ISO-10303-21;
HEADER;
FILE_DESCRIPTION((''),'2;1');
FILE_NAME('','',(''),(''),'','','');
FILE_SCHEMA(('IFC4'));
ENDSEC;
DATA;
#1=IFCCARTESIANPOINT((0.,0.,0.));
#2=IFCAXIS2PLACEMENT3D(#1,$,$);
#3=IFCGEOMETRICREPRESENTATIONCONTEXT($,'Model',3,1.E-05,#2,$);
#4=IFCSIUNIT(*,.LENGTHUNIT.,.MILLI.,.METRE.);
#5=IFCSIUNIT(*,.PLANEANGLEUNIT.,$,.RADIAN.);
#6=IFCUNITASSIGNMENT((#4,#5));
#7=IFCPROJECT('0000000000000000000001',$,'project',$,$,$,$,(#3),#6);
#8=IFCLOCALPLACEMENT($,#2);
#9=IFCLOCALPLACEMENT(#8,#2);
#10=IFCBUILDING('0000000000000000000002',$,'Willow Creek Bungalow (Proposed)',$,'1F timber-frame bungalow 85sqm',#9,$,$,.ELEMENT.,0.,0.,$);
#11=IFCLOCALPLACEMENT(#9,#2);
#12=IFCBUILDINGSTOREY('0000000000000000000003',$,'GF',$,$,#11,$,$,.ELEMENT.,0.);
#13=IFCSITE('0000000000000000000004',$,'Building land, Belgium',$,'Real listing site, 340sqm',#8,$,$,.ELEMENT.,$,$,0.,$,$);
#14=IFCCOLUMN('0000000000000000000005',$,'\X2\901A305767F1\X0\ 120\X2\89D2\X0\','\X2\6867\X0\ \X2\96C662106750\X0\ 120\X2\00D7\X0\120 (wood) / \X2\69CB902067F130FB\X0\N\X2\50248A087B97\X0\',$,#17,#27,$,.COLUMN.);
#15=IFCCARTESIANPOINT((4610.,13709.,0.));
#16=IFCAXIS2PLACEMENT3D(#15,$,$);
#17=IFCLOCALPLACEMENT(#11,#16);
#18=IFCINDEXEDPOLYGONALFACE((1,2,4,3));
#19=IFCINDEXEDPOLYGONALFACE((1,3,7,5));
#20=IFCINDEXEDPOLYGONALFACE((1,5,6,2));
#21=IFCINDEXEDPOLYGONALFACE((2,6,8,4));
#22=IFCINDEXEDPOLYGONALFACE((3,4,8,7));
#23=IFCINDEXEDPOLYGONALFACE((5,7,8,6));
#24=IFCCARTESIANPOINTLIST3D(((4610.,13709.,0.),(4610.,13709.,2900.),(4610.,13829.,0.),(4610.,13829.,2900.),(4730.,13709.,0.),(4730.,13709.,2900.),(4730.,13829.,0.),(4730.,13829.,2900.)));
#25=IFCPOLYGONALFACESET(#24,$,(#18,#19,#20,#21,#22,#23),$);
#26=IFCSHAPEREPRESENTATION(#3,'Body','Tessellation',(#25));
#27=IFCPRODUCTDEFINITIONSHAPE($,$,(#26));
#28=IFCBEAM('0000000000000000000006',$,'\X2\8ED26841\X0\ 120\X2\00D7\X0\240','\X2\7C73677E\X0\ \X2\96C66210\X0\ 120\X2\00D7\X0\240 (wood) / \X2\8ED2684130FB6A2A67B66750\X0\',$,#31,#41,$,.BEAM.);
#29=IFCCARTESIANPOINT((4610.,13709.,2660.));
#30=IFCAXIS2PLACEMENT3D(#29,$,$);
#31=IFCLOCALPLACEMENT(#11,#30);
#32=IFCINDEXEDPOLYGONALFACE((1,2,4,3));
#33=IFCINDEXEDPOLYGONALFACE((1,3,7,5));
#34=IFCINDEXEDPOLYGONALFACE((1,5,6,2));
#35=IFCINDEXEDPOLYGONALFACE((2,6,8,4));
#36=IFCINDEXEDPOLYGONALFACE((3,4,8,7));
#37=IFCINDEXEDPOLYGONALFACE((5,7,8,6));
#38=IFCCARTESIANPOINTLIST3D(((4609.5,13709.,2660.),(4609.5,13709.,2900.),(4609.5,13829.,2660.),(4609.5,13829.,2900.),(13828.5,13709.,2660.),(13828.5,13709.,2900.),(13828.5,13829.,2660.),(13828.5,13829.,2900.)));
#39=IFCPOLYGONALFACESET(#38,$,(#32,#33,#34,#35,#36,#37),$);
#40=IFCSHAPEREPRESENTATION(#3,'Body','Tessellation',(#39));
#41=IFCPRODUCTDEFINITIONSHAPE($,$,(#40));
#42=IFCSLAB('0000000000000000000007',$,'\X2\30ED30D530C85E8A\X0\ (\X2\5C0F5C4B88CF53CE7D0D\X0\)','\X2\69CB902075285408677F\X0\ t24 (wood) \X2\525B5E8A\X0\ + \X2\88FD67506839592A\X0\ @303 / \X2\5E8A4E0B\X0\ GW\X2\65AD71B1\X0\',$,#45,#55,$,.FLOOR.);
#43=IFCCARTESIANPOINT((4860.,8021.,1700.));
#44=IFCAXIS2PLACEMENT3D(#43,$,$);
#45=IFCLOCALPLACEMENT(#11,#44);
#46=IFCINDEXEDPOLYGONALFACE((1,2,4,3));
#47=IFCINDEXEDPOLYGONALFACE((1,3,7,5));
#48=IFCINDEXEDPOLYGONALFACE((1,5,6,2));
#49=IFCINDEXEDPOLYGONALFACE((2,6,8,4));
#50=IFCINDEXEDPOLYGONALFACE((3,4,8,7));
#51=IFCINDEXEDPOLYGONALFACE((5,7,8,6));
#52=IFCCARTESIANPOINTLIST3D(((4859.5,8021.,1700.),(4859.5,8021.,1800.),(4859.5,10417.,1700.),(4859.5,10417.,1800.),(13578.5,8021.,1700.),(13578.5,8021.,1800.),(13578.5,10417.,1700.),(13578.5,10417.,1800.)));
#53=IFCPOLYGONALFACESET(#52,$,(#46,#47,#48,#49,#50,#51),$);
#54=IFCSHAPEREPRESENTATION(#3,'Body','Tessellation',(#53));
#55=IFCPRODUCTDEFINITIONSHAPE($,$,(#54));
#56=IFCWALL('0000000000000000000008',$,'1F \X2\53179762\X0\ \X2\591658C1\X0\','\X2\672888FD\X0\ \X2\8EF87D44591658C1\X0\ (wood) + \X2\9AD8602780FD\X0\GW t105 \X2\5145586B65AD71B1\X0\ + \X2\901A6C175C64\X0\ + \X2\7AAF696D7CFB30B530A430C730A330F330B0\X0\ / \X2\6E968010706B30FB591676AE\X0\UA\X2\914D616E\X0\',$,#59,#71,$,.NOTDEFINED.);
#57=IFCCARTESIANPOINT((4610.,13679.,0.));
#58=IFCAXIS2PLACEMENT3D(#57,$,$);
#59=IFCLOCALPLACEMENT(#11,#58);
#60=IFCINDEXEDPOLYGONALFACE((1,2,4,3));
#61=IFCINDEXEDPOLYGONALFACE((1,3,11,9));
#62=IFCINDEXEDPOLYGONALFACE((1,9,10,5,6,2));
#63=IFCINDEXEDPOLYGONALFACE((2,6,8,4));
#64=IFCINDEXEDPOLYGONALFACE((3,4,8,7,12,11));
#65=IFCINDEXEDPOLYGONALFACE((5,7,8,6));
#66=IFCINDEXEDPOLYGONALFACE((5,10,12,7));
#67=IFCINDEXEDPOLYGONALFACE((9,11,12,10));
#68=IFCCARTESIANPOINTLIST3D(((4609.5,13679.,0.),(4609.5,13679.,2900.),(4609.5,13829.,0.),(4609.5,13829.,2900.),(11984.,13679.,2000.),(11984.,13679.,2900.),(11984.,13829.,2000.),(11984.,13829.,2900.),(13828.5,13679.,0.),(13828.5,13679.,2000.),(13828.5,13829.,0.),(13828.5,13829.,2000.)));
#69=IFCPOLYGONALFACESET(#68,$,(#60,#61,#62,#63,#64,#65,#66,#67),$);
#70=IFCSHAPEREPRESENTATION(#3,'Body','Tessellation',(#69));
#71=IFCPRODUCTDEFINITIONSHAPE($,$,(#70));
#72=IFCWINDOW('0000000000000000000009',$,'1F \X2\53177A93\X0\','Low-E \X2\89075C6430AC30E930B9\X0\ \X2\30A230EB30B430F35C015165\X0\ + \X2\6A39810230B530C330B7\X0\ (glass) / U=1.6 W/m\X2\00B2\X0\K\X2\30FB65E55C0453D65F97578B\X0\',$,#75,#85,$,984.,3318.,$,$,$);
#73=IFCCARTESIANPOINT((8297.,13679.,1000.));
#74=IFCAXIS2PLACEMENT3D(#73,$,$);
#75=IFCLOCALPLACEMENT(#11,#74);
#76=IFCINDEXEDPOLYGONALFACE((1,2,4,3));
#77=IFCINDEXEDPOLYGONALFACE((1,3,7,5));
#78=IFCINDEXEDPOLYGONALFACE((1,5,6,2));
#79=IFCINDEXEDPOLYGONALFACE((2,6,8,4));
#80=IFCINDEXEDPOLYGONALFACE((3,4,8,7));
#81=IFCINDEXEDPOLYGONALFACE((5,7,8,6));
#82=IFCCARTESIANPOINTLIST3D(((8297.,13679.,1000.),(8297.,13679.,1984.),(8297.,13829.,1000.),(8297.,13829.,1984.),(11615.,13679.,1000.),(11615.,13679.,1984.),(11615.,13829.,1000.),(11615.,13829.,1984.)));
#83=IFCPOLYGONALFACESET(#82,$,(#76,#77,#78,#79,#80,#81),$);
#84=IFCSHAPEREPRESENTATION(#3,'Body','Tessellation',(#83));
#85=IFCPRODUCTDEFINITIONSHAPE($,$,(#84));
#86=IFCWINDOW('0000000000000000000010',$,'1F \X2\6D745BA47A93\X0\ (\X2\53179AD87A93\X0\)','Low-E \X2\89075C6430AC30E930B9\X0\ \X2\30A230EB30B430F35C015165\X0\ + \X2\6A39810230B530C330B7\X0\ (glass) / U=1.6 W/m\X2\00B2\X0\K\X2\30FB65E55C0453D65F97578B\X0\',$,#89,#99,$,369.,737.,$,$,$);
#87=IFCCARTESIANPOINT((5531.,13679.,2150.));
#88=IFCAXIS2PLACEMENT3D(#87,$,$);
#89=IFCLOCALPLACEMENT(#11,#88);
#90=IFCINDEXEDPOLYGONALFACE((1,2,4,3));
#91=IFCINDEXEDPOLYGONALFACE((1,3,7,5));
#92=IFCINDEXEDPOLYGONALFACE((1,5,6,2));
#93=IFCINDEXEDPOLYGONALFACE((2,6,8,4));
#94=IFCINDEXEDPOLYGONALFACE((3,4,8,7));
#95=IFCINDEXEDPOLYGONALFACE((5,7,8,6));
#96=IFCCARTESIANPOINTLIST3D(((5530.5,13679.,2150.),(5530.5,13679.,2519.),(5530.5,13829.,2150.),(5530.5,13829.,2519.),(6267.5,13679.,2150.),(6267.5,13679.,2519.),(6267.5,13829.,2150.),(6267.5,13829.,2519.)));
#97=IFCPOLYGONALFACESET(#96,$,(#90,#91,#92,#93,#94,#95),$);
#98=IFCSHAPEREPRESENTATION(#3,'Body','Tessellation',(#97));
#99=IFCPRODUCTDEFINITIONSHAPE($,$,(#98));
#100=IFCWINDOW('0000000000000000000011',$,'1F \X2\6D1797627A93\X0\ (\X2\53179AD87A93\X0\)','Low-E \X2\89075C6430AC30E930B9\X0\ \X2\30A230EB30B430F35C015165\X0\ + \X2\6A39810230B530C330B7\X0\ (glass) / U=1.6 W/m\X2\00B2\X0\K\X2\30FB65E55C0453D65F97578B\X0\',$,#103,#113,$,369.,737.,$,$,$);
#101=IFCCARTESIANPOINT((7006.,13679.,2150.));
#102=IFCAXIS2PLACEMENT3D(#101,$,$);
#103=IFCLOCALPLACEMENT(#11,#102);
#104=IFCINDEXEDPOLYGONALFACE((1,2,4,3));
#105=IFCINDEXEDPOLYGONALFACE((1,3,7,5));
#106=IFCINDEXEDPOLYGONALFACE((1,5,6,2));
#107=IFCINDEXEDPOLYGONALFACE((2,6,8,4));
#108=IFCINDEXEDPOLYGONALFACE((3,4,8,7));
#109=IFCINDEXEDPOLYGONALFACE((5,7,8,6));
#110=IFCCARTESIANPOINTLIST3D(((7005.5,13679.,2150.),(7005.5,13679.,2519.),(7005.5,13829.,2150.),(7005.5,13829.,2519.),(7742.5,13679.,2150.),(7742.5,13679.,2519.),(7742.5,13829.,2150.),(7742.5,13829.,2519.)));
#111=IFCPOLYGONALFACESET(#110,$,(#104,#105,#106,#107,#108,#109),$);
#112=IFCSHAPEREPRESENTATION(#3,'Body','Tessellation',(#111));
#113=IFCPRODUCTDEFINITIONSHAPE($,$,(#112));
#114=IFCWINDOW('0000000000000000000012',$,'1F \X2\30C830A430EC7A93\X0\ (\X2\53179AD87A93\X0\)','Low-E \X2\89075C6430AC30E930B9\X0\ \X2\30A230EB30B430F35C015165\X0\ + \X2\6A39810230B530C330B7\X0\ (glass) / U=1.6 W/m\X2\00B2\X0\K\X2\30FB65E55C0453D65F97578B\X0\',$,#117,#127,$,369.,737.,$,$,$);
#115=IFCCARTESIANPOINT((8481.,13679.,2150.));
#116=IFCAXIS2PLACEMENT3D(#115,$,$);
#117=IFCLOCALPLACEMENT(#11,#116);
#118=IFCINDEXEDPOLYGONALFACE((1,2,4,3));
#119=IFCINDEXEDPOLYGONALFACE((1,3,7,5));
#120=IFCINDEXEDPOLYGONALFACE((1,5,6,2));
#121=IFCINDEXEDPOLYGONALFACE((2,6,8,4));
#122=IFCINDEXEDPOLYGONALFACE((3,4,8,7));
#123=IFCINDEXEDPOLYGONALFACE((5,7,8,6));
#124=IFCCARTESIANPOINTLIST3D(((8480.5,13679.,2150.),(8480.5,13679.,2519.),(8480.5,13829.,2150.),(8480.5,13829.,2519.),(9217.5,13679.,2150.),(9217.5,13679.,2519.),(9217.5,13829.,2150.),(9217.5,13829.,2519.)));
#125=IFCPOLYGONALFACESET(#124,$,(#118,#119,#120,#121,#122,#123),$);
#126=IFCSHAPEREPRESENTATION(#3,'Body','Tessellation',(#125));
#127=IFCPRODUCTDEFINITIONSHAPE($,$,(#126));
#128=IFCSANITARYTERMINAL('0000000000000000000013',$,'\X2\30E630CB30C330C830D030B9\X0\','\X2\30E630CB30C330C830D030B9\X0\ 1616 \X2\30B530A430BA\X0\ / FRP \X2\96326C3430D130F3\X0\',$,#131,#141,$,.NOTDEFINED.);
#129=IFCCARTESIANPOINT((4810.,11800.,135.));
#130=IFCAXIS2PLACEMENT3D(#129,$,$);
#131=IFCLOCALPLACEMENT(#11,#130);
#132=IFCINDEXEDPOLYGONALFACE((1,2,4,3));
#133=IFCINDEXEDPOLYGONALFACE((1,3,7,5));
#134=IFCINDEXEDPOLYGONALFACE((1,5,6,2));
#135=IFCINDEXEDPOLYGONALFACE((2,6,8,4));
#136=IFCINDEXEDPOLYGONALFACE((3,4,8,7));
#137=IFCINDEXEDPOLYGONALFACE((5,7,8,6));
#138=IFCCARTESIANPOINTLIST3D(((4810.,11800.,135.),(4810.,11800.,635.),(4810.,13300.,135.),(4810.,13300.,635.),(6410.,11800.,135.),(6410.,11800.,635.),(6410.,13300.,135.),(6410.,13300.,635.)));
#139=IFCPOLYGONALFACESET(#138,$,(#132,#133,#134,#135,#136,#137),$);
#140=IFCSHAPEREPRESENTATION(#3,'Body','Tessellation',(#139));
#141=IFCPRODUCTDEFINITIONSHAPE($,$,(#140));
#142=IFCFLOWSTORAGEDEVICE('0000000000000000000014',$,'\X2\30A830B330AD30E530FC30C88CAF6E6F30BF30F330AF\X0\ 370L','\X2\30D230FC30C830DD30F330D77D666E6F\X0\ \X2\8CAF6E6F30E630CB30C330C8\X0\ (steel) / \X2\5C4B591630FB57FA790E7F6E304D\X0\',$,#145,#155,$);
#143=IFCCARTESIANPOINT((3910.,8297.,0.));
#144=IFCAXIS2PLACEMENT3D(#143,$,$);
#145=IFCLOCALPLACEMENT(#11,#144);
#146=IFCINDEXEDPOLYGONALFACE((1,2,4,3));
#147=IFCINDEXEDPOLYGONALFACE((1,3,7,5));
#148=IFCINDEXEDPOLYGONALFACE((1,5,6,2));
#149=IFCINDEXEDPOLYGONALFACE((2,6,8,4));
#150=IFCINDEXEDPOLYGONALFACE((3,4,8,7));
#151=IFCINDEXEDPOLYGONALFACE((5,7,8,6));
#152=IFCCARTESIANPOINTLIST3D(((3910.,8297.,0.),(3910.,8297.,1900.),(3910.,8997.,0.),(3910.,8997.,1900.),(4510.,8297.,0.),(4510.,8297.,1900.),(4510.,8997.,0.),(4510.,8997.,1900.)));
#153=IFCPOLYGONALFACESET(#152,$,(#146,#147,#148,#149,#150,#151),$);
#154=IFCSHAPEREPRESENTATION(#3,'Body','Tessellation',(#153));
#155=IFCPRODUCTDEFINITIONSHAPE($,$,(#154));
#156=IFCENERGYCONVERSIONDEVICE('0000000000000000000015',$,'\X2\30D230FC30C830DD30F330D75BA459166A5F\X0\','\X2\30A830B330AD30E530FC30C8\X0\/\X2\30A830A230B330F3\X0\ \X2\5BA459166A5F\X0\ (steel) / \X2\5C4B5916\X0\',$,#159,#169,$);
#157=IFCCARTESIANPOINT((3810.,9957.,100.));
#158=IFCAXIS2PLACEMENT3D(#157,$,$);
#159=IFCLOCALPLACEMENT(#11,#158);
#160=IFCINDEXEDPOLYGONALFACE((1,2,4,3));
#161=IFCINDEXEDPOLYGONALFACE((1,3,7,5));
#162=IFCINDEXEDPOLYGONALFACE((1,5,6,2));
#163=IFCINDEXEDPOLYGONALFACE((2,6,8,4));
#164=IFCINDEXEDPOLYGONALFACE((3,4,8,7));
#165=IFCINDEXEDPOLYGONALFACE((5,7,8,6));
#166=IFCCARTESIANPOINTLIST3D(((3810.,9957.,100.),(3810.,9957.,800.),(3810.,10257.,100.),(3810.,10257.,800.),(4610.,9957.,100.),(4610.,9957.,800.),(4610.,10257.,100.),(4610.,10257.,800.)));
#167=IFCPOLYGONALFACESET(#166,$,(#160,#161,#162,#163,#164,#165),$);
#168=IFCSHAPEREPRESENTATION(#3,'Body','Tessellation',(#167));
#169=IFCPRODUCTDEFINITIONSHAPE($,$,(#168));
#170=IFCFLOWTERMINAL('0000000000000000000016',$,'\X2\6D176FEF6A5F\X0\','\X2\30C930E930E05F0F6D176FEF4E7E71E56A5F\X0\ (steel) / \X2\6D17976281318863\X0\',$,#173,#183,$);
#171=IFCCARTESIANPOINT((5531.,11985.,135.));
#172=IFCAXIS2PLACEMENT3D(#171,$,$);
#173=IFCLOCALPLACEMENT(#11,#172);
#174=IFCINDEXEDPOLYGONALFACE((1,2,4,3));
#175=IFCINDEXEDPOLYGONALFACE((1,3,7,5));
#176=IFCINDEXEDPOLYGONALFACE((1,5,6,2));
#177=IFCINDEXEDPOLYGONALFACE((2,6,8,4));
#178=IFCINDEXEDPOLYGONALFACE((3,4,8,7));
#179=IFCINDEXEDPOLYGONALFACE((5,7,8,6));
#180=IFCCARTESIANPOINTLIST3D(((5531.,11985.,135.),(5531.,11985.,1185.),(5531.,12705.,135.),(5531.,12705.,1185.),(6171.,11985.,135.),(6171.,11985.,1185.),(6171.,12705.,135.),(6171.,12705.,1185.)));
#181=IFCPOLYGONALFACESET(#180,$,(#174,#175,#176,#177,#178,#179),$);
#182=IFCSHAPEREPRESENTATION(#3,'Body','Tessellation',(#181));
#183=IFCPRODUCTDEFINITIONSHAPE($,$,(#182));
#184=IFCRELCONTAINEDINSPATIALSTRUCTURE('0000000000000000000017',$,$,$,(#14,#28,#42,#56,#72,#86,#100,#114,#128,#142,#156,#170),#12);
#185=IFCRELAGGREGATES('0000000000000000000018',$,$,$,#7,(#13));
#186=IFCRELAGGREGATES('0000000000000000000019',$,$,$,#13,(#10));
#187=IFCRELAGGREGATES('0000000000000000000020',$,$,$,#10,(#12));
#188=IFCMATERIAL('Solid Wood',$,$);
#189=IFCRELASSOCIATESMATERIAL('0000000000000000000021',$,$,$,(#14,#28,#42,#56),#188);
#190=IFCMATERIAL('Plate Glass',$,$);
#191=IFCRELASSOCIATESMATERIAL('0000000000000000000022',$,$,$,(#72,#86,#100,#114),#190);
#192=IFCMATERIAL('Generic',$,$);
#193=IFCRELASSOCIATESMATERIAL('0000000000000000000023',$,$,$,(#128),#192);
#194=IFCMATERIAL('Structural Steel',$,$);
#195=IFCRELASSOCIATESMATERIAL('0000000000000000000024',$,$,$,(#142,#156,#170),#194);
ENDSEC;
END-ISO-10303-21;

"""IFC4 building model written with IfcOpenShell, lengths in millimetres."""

from ifc_helpers import new_model, si_unit, frame, frame_2d, origin, place, context, project, spatial, rectangle, extrude, material, element, fill, save


model = new_model("IFC4")

# Units and contexts
model_context = context("Model", 3, precision=1e-05, world=origin())
ifc_project = project(units=[si_unit("LENGTHUNIT", "METRE", prefix="MILLI"), si_unit("PLANEANGLEUNIT", "RADIAN")], contexts=[model_context])

# Site, building, storey
site_placement = place(None, origin())
site = spatial("IfcSite", under=ifc_project, at=site_placement, Name="Building land, Belgium", ObjectType="Real listing site, 340sqm", CompositionType="ELEMENT", RefElevation=0.0)
building_placement = place(site_placement, origin())
building = spatial("IfcBuilding", under=site, at=building_placement, Name="Willow Creek Bungalow (Proposed)", ObjectType="1F timber-frame bungalow 85sqm", CompositionType="ELEMENT", ElevationOfRefHeight=0.0, ElevationOfTerrain=0.0)
storey_placement = place(building_placement, origin())
storey = spatial("IfcBuildingStorey", under=building, at=storey_placement, Name="GF", CompositionType="ELEMENT", Elevation=0.0)

# Column
ifc_material_1 = material(Name="Solid Wood")
column_1_placement = place(storey_placement, frame((4610.0, 13709.0, 0.0)))
element("IfcColumn", 1, at=column_1_placement, inside=storey, material=ifc_material_1, Name="通し柱 120角", Description="桧 集成材 120×120 (wood) / 構造柱・N値計算", PredefinedType="COLUMN", context=model_context, shape_type="SweptSolid", body=[
    extrude(rectangle(XDim=120.0, YDim=120.0, at=frame_2d((60.0, 60.0))), frame((4610.0, 13709.0, 0.0)), (0.0, 0.0, 1.0), 2900.0),
])

# Beam
beam_1_placement = place(storey_placement, frame((4610.0, 13709.0, 2660.0)))
element("IfcBeam", 2, at=beam_1_placement, inside=storey, material=ifc_material_1, Name="軒桁 120×240", Description="米松 集成 120×240 (wood) / 軒桁・横架材", PredefinedType="BEAM", context=model_context, shape_type="SweptSolid", body=[
    extrude(rectangle(XDim=9219.0, YDim=120.0, at=frame_2d((4609.0, 60.0))), frame((4610.0, 13709.0, 2660.0)), (0.0, 0.0, 1.0), 240.0),
])

# Slab
slab_placement = place(storey_placement, frame((4860.0, 8021.0, 1700.0)))
element("IfcSlab", 3, at=slab_placement, inside=storey, material=ifc_material_1, Name="ロフト床 (小屋裏収納)", Description="構造用合板 t24 (wood) 剛床 + 製材根太 @303 / 床下 GW断熱", PredefinedType="FLOOR", context=model_context, shape_type="SweptSolid", body=[
    extrude(rectangle(XDim=8719.0, YDim=2396.0, at=frame_2d((4359.0, 1198.0))), frame((4860.0, 8021.0, 1700.0)), (0.0, 0.0, 1.0), 100.0),
])

# Wall, openings, windows
wall_1_placement = place(storey_placement, frame((4610.0, 13679.0, 0.0)))
wall_1 = element("IfcWall", 4, at=wall_1_placement, inside=storey, material=ifc_material_1, Name="1F 北面 外壁", Description="木製 軸組外壁 (wood) + 高性能GW t105 充填断熱 + 通気層 + 窯業系サイディング / 準耐火・外皮UA配慮", PredefinedType="NOTDEFINED", context=model_context, shape_type="SweptSolid", body=[
    extrude(rectangle(XDim=9219.0, YDim=150.0, at=frame_2d((4609.0, 75.0))), frame((4610.0, 13679.0, 0.0)), (0.0, 0.0, 1.0), 2900.0),
])
opening_1_placement = place(storey_placement, frame((8297.0, 13679.0, 1000.0)))
opening_1 = element("IfcOpeningElement", 5, at=opening_1_placement, cuts=wall_1, PredefinedType="NOTDEFINED", context=model_context, shape_type="SweptSolid", body=[
    extrude(rectangle(XDim=3318.0, YDim=150.0, at=frame_2d((1659.0, 75.0))), frame((8297.0, 13679.0, 1000.0)), (0.0, 0.0, 1.0), 984.0),
])
opening_2_placement = place(storey_placement, frame((5531.0, 13679.0, 2150.0)))
opening_2 = element("IfcOpeningElement", 6, at=opening_2_placement, cuts=wall_1, PredefinedType="NOTDEFINED", context=model_context, shape_type="SweptSolid", body=[
    extrude(rectangle(XDim=737.0, YDim=150.0, at=frame_2d((368.0, 75.0))), frame((5531.0, 13679.0, 2150.0)), (0.0, 0.0, 1.0), 369.0),
])
opening_3_placement = place(storey_placement, frame((7006.0, 13679.0, 2150.0)))
opening_3 = element("IfcOpeningElement", 7, at=opening_3_placement, cuts=wall_1, PredefinedType="NOTDEFINED", context=model_context, shape_type="SweptSolid", body=[
    extrude(rectangle(XDim=737.0, YDim=150.0, at=frame_2d((368.0, 75.0))), frame((7006.0, 13679.0, 2150.0)), (0.0, 0.0, 1.0), 369.0),
])
opening_4_placement = place(storey_placement, frame((8481.0, 13679.0, 2150.0)))
opening_4 = element("IfcOpeningElement", 8, at=opening_4_placement, cuts=wall_1, PredefinedType="NOTDEFINED", context=model_context, shape_type="SweptSolid", body=[
    extrude(rectangle(XDim=737.0, YDim=150.0, at=frame_2d((368.0, 75.0))), frame((8481.0, 13679.0, 2150.0)), (0.0, 0.0, 1.0), 369.0),
])
ifc_material_2 = material(Name="Plate Glass")
window_1_placement = place(storey_placement, frame((8297.0, 13679.0, 1000.0)))
window_1 = element("IfcWindow", 9, at=window_1_placement, inside=storey, material=ifc_material_2, Name="1F 北窓", Description="Low-E 複層ガラス アルゴン封入 + 樹脂サッシ (glass) / U=1.6 W/m²K・日射取得型", OverallHeight=984.0, OverallWidth=3318.0, context=model_context, shape_type="SweptSolid", body=[
    extrude(rectangle(XDim=3318.0, YDim=150.0, at=frame_2d((1659.0, 75.0))), frame((8297.0, 13679.0, 1000.0)), (0.0, 0.0, 1.0), 984.0),
])
fill(opening_1, window_1)
window_2_placement = place(storey_placement, frame((5531.0, 13679.0, 2150.0)))
window_2 = element("IfcWindow", 10, at=window_2_placement, inside=storey, material=ifc_material_2, Name="1F 浴室窓 (北高窓)", Description="Low-E 複層ガラス アルゴン封入 + 樹脂サッシ (glass) / U=1.6 W/m²K・日射取得型", OverallHeight=369.0, OverallWidth=737.0, context=model_context, shape_type="SweptSolid", body=[
    extrude(rectangle(XDim=737.0, YDim=150.0, at=frame_2d((368.0, 75.0))), frame((5531.0, 13679.0, 2150.0)), (0.0, 0.0, 1.0), 369.0),
])
fill(opening_2, window_2)
window_3_placement = place(storey_placement, frame((7006.0, 13679.0, 2150.0)))
window_3 = element("IfcWindow", 11, at=window_3_placement, inside=storey, material=ifc_material_2, Name="1F 洗面窓 (北高窓)", Description="Low-E 複層ガラス アルゴン封入 + 樹脂サッシ (glass) / U=1.6 W/m²K・日射取得型", OverallHeight=369.0, OverallWidth=737.0, context=model_context, shape_type="SweptSolid", body=[
    extrude(rectangle(XDim=737.0, YDim=150.0, at=frame_2d((368.0, 75.0))), frame((7006.0, 13679.0, 2150.0)), (0.0, 0.0, 1.0), 369.0),
])
fill(opening_3, window_3)
window_4_placement = place(storey_placement, frame((8481.0, 13679.0, 2150.0)))
window_4 = element("IfcWindow", 12, at=window_4_placement, inside=storey, material=ifc_material_2, Name="1F トイレ窓 (北高窓)", Description="Low-E 複層ガラス アルゴン封入 + 樹脂サッシ (glass) / U=1.6 W/m²K・日射取得型", OverallHeight=369.0, OverallWidth=737.0, context=model_context, shape_type="SweptSolid", body=[
    extrude(rectangle(XDim=737.0, YDim=150.0, at=frame_2d((368.0, 75.0))), frame((8481.0, 13679.0, 2150.0)), (0.0, 0.0, 1.0), 369.0),
])
fill(opening_4, window_4)

# Sanitary terminal
ifc_material_3 = material(Name="Generic")
sanitary_terminal_placement = place(storey_placement, frame((4810.0, 11800.0, 135.0)))
element("IfcSanitaryTerminal", 13, at=sanitary_terminal_placement, inside=storey, material=ifc_material_3, Name="ユニットバス", Description="ユニットバス 1616 サイズ / FRP 防水パン", PredefinedType="NOTDEFINED", context=model_context, shape_type="SweptSolid", body=[
    extrude(rectangle(XDim=1600.0, YDim=1500.0, at=frame_2d((800.0, 750.0))), frame((4810.0, 11800.0, 135.0)), (0.0, 0.0, 1.0), 500.0),
])

# Flow storage device
ifc_material_4 = material(Name="Structural Steel")
flow_storage_device_placement = place(storey_placement, frame((3910.0, 8297.0, 0.0)))
element("IfcFlowStorageDevice", 14, at=flow_storage_device_placement, inside=storey, material=ifc_material_4, Name="エコキュート貯湯タンク 370L", Description="ヒートポンプ給湯 貯湯ユニット (steel) / 屋外・基礎置き", context=model_context, shape_type="SweptSolid", body=[
    extrude(rectangle(XDim=600.0, YDim=700.0, at=frame_2d((300.0, 350.0))), frame((3910.0, 8297.0, 0.0)), (0.0, 0.0, 1.0), 1900.0),
])

# Energy conversion device
energy_conversion_device_placement = place(storey_placement, frame((3810.0, 9957.0, 100.0)))
element("IfcEnergyConversionDevice", 15, at=energy_conversion_device_placement, inside=storey, material=ifc_material_4, Name="ヒートポンプ室外機", Description="エコキュート/エアコン 室外機 (steel) / 屋外", context=model_context, shape_type="SweptSolid", body=[
    extrude(rectangle(XDim=800.0, YDim=300.0, at=frame_2d((400.0, 150.0))), frame((3810.0, 9957.0, 100.0)), (0.0, 0.0, 1.0), 700.0),
])

# Flow terminal
flow_terminal_placement = place(storey_placement, frame((5531.0, 11985.0, 135.0)))
element("IfcFlowTerminal", 16, at=flow_terminal_placement, inside=storey, material=ifc_material_4, Name="洗濯機", Description="ドラム式洗濯乾燥機 (steel) / 洗面脱衣", context=model_context, shape_type="SweptSolid", body=[
    extrude(rectangle(XDim=640.0, YDim=720.0, at=frame_2d((320.0, 360.0))), frame((5531.0, 11985.0, 135.0)), (0.0, 0.0, 1.0), 1050.0),
])

save(model, "model.ifc")
